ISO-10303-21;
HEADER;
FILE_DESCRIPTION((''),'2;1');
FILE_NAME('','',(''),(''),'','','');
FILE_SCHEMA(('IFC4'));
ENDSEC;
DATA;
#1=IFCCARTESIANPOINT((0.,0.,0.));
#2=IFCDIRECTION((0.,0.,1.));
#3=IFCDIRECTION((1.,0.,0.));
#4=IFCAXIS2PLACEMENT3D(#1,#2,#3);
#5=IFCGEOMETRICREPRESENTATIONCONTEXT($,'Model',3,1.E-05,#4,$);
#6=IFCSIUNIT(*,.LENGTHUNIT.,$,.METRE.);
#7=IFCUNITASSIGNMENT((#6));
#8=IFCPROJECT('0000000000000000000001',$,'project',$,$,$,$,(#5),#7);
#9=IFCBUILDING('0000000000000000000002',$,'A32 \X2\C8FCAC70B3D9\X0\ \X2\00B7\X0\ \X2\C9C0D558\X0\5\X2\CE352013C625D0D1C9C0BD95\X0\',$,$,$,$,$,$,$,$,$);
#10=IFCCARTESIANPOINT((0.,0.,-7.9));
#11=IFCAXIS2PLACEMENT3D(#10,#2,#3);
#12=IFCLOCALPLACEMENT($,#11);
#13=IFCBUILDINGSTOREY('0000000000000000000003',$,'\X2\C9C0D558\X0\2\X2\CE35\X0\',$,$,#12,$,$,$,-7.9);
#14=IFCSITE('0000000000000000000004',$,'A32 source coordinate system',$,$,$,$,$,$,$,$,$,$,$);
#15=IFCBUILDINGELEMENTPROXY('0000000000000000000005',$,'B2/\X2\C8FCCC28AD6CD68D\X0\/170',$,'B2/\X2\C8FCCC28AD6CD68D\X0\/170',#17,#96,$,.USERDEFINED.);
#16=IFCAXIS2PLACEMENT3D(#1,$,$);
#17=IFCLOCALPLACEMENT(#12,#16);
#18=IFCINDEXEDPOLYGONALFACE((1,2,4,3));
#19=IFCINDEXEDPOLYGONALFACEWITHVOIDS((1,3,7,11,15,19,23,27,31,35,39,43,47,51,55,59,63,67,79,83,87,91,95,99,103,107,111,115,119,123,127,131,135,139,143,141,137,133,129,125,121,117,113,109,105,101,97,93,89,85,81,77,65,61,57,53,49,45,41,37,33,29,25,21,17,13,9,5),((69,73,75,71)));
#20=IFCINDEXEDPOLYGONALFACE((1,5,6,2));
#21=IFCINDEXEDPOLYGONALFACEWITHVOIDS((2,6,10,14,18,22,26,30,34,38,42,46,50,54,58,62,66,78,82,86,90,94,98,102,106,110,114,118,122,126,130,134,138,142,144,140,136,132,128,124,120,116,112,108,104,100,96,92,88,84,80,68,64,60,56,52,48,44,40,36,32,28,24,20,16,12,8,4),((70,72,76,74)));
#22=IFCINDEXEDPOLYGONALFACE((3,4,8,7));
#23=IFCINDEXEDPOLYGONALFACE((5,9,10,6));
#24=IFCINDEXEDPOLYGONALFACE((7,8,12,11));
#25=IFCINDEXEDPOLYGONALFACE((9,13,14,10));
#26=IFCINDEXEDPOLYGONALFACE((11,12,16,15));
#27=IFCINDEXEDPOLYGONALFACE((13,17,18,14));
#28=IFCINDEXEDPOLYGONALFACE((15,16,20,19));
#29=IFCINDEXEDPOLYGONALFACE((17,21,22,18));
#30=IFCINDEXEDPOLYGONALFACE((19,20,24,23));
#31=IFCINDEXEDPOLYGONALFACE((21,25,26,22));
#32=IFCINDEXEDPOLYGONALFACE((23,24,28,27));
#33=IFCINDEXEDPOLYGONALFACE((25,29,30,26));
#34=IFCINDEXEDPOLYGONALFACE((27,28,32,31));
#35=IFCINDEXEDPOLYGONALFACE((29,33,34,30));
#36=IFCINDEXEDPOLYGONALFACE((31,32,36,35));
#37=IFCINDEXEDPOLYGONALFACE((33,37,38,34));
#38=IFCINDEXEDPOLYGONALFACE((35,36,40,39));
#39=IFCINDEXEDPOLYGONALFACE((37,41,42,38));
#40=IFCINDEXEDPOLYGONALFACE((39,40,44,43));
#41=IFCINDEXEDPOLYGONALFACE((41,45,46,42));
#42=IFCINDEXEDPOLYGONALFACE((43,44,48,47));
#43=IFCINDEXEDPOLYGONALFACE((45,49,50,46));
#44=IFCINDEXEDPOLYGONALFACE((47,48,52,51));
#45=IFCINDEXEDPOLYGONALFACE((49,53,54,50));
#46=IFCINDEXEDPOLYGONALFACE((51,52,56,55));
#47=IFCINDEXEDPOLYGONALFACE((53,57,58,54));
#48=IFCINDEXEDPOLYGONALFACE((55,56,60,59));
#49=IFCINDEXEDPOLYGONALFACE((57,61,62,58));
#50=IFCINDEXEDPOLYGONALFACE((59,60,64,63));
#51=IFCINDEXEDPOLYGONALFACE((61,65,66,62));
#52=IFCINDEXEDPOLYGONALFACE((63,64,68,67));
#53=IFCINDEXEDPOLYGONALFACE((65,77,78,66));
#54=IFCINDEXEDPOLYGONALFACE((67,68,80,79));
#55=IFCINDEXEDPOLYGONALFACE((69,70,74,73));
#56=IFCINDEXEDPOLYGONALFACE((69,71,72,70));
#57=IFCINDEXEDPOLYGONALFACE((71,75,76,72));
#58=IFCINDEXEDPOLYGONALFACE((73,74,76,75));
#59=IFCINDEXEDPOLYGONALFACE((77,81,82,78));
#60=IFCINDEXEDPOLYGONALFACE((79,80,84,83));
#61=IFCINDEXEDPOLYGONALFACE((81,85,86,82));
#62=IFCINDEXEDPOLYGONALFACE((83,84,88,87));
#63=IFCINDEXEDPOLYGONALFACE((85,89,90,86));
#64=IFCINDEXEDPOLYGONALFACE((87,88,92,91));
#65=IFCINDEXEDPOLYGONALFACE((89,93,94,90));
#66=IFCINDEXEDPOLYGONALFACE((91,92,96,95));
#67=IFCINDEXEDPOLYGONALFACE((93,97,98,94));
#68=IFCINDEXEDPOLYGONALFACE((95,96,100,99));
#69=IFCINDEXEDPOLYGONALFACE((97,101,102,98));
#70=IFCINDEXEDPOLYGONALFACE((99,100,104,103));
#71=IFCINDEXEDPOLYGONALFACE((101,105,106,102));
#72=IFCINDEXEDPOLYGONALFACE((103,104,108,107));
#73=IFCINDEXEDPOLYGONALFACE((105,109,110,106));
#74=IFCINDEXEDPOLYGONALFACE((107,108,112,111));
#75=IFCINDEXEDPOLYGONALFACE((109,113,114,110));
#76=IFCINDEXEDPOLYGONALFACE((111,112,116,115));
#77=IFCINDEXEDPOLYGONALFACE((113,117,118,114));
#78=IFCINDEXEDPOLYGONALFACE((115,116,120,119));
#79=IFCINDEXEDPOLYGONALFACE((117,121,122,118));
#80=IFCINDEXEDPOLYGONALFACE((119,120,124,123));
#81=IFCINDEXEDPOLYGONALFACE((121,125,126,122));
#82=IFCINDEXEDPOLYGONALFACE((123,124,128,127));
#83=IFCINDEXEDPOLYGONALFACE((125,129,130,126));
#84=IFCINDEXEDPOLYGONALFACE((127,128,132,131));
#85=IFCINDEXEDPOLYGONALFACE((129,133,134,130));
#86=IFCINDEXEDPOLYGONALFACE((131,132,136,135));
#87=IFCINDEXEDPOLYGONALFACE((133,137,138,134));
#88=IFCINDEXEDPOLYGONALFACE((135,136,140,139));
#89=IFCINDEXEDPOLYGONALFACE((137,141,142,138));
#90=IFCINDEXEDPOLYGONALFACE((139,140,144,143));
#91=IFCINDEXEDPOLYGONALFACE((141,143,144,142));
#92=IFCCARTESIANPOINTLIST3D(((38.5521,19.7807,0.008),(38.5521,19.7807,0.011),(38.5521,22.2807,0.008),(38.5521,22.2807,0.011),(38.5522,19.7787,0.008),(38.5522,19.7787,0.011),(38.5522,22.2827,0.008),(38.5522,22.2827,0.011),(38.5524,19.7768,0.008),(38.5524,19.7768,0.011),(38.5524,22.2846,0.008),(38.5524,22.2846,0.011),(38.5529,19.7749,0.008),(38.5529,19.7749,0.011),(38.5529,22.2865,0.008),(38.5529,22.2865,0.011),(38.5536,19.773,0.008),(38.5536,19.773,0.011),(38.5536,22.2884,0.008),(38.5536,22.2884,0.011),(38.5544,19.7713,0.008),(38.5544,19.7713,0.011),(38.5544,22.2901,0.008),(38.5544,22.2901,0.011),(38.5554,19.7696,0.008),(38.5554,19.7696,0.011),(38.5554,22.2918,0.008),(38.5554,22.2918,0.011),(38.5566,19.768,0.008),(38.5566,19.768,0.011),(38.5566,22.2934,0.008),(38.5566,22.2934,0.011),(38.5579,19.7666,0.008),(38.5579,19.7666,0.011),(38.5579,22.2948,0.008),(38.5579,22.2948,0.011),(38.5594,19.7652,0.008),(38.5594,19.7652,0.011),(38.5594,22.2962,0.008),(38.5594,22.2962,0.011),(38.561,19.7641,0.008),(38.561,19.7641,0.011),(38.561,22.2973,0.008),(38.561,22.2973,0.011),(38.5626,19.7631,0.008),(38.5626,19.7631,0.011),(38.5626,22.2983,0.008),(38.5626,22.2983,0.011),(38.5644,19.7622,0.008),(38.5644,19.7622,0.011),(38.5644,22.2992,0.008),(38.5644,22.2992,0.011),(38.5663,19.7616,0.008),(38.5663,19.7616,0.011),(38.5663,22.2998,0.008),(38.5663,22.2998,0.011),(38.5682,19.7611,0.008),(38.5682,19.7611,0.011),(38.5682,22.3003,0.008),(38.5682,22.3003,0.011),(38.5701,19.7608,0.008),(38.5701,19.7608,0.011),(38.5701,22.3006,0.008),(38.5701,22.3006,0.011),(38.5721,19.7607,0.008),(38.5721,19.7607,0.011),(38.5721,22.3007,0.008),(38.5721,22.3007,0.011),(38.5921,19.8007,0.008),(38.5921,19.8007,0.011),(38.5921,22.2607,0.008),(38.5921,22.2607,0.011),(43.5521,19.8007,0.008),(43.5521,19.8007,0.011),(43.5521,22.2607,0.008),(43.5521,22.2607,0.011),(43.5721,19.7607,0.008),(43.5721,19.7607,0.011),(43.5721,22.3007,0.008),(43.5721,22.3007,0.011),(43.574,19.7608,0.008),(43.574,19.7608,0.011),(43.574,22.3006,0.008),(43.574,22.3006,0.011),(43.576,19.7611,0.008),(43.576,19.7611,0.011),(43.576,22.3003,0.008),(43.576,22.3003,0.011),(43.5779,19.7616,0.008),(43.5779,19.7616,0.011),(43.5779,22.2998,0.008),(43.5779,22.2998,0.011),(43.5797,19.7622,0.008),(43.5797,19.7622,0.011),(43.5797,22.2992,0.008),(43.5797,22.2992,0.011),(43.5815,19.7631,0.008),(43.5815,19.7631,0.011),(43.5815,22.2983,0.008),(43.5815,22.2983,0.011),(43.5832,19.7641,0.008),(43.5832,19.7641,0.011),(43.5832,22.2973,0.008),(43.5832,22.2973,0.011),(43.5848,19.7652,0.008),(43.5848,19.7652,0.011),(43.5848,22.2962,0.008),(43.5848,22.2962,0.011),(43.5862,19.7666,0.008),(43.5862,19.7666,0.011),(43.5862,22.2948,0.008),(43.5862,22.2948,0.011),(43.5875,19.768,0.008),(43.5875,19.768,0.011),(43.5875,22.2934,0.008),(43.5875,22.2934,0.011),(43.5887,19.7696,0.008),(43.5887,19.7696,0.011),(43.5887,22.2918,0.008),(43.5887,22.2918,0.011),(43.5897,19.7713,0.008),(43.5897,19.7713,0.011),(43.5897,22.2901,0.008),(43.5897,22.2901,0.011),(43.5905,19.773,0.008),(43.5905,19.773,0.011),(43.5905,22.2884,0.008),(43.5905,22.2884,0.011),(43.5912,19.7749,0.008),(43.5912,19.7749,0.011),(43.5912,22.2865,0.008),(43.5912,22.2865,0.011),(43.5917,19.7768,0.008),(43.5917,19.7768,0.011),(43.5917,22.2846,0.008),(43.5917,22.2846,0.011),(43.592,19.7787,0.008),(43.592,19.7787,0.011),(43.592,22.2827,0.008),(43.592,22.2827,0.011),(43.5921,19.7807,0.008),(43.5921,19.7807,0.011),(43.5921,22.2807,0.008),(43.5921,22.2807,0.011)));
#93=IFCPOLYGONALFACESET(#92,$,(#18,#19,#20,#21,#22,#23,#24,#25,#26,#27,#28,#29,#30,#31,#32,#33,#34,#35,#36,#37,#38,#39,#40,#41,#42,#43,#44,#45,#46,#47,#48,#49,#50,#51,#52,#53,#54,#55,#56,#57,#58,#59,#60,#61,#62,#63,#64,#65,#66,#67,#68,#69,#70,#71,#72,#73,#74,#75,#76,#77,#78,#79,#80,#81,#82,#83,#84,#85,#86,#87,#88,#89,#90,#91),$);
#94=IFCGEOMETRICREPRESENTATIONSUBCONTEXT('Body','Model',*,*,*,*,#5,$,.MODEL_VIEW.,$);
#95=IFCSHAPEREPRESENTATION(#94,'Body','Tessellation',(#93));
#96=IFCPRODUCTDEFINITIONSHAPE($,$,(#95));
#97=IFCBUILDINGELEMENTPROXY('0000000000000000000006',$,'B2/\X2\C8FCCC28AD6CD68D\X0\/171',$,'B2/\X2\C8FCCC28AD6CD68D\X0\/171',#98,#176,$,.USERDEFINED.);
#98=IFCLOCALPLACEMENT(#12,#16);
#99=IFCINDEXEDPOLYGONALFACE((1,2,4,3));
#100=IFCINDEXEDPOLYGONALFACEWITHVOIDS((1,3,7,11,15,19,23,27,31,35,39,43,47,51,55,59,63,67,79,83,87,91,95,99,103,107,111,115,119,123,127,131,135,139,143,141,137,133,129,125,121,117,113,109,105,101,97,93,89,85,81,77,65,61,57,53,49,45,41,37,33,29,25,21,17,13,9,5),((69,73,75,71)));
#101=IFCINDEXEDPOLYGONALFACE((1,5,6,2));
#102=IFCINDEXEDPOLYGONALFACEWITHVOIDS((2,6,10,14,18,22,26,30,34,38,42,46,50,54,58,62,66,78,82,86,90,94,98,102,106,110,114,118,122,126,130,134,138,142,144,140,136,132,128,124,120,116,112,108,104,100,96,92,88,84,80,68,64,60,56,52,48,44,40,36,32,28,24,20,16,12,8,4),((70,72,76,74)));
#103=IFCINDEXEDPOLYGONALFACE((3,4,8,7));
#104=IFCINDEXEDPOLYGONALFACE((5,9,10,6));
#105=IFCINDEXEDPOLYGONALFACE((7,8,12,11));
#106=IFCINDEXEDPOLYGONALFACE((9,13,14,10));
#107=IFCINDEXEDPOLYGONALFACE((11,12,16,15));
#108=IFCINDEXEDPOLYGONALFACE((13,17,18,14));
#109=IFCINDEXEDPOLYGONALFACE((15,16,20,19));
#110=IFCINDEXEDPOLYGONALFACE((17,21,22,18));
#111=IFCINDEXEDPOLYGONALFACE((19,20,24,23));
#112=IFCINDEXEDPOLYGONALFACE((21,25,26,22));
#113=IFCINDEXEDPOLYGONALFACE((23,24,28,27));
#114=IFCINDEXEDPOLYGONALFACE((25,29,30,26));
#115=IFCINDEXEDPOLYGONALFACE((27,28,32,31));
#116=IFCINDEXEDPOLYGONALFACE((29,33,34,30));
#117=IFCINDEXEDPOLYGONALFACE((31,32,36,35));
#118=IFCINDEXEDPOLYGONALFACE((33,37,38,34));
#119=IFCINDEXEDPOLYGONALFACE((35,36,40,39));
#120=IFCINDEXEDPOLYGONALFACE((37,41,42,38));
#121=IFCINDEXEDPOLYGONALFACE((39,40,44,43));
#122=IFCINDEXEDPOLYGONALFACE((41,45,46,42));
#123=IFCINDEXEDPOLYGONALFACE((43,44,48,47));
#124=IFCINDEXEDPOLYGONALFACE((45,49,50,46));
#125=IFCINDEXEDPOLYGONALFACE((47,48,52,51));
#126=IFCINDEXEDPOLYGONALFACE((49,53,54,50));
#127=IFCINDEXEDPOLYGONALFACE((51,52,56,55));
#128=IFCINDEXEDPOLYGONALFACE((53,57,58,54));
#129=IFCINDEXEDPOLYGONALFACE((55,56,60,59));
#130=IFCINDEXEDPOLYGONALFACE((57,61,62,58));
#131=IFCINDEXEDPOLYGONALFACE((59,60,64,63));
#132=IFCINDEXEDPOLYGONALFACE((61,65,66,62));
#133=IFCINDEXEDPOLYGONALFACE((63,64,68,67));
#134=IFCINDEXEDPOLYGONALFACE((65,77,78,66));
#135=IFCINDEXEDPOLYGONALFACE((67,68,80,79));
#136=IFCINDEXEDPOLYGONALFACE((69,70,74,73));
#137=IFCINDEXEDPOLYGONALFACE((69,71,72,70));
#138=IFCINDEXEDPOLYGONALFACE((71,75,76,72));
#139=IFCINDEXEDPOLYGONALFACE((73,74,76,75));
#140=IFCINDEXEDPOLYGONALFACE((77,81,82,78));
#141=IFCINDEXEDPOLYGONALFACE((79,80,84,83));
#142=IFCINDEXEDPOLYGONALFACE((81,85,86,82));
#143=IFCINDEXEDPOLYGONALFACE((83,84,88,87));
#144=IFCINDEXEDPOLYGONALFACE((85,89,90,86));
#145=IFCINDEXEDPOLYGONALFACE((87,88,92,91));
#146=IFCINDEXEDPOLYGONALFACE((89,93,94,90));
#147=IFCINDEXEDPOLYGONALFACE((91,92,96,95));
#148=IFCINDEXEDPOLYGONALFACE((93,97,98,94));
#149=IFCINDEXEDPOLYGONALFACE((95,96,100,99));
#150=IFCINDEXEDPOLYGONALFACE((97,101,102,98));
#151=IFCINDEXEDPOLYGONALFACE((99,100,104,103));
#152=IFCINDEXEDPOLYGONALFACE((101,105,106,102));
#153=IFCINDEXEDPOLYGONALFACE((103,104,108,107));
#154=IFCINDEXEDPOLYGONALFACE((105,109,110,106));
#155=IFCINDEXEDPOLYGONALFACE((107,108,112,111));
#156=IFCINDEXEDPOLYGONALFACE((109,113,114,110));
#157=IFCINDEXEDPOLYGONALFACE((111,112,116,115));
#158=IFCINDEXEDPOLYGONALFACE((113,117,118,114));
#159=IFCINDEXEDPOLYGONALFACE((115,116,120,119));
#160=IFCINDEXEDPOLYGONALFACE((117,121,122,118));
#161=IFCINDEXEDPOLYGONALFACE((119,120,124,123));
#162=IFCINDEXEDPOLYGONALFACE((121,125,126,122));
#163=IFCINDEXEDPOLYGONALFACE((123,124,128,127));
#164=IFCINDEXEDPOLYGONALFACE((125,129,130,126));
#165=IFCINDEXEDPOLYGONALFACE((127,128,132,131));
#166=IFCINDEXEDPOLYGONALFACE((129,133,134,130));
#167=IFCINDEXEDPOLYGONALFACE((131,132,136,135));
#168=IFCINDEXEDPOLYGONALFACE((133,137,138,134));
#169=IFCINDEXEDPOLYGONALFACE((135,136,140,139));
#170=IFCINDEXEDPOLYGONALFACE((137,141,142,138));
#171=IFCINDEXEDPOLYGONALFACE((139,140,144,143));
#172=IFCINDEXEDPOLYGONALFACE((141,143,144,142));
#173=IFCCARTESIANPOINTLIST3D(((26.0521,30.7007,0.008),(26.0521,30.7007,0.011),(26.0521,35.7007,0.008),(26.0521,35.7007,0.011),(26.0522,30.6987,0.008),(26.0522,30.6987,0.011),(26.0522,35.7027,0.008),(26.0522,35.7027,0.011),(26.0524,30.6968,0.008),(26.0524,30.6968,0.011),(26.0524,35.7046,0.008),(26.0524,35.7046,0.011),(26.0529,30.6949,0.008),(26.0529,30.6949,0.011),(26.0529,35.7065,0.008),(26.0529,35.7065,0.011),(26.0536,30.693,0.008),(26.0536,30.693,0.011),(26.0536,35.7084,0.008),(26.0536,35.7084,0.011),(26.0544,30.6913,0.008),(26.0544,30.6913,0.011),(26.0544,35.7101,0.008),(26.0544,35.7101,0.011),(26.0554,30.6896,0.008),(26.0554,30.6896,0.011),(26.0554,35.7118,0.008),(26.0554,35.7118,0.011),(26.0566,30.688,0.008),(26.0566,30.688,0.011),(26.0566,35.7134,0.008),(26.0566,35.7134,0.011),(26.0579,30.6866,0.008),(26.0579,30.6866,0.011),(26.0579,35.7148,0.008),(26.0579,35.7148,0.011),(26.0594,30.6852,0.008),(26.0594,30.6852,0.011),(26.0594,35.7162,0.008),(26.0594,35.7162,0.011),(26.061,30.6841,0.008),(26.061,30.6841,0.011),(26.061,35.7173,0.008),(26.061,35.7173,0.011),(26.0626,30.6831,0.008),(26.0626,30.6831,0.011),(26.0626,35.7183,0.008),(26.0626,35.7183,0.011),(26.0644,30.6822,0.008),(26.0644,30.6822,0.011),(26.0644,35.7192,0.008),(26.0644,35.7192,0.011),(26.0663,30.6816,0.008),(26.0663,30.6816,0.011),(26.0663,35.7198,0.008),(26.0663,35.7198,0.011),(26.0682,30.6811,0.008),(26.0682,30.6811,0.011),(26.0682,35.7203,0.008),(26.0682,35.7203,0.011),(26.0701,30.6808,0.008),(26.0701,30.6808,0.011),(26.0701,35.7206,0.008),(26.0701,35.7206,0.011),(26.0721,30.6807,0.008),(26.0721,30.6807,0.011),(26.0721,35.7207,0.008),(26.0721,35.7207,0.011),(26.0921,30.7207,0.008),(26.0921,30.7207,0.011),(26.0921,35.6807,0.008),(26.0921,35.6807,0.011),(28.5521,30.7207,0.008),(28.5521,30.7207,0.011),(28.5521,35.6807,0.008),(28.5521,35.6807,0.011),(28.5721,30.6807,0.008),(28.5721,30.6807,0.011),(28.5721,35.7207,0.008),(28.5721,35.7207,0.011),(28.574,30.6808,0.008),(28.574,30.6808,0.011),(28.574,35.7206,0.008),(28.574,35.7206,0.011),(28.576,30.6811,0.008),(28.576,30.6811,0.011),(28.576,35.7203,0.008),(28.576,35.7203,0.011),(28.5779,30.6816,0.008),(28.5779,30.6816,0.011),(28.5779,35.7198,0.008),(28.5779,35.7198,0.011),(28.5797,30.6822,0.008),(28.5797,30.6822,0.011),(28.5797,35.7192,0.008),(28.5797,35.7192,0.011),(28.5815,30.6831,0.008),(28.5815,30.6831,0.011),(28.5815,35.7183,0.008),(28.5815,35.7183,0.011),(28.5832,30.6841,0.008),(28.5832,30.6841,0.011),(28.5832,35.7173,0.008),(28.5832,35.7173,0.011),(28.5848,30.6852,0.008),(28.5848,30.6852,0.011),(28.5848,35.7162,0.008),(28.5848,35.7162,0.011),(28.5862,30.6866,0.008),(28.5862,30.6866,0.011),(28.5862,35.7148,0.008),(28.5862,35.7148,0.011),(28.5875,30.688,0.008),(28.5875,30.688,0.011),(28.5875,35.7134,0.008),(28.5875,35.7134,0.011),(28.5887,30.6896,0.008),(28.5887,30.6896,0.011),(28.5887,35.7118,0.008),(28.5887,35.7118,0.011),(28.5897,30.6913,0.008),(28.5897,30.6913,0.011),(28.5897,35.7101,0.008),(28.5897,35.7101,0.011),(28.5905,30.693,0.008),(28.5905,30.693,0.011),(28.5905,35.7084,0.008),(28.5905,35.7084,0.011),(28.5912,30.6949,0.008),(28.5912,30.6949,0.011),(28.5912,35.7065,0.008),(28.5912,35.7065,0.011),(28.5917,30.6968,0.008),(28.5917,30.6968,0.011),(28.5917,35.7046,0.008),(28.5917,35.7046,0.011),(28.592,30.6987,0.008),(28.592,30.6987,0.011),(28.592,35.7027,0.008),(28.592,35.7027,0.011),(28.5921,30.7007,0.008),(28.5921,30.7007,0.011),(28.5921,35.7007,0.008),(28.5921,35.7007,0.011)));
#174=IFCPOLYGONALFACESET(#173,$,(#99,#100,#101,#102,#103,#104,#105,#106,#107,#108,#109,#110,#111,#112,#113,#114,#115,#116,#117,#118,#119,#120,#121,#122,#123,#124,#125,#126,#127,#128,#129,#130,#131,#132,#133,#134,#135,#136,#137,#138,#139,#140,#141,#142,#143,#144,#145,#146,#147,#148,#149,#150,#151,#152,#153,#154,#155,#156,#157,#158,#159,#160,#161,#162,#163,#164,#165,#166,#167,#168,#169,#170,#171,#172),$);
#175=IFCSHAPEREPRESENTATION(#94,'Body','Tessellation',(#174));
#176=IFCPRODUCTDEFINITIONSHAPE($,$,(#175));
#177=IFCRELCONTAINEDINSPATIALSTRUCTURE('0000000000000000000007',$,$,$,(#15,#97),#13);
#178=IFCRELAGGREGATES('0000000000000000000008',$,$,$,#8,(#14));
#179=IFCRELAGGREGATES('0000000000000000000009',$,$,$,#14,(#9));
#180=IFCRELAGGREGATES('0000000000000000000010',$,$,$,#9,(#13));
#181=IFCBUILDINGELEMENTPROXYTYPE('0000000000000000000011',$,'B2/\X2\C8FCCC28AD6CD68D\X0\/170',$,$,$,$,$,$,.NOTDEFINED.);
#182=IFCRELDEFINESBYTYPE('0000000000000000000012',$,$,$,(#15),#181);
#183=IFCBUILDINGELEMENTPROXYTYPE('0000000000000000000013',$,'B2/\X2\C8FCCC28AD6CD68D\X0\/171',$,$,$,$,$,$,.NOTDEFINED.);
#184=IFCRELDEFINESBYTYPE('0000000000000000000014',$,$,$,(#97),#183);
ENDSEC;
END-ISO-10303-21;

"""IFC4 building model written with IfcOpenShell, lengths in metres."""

from ifc_helpers import new_model, si_unit, frame, origin, origin_with_axes, place, context, subcontext, project, spatial, polyline, outline, extrude, source, transform, mapped, type_object, type_shapes, element, save


model = new_model("IFC4")

# Units and contexts
model_context = context("Model", 3, precision=1e-05, world=origin_with_axes())
body_context = subcontext(model_context, "Body", "Model", "MODEL_VIEW")
ifc_project = project(units=[si_unit("LENGTHUNIT", "METRE")], contexts=[model_context])

# Site, building, storey
site = spatial("IfcSite", under=ifc_project, Name="A32 source coordinate system")
building = spatial("IfcBuilding", under=site, Name="A32 주거동 · 지하5층–옥탑지붕")
storey_placement = place(None, frame((0.0, 0.0, -7.9), z_axis=(0.0, 0.0, 1.0), x_axis=(1.0, 0.0, 0.0)))
storey = spatial("IfcBuildingStorey", under=building, at=storey_placement, Name="지하2층", Elevation=-7.9)

# Building element proxies
building_element_proxy_type_1 = type_object("IfcBuildingElementProxyType", Name="B2/주차구획/170", PredefinedType="NOTDEFINED")
shared_shape_1 = source(origin(), body_context, "Body", "SweptSolid", [
    extrude(outline(polyline([(43.5721, 22.3007), (43.574, 22.3006), (43.576, 22.3003), (43.5779, 22.2998), (43.5797, 22.2992), (43.5815, 22.2983), (43.5832, 22.2973), (43.5848, 22.2962), (43.5862, 22.2948), (43.5875, 22.2934), (43.5887, 22.2918), (43.5897, 22.2901), (43.5905, 22.2884), (43.5912, 22.2865), (43.5917, 22.2846), (43.592, 22.2827), (43.5921, 22.2807), (43.5921, 19.7807), (43.592, 19.7787), (43.5917, 19.7768), (43.5912, 19.7749), (43.5905, 19.773), (43.5897, 19.7713), (43.5887, 19.7696), (43.5875, 19.768), (43.5862, 19.7666), (43.5848, 19.7652), (43.5832, 19.7641), (43.5815, 19.7631), (43.5797, 19.7622), (43.5779, 19.7616), (43.576, 19.7611), (43.574, 19.7608), (43.5721, 19.7607), (38.5721, 19.7607), (38.5701, 19.7608), (38.5682, 19.7611), (38.5663, 19.7616), (38.5644, 19.7622), (38.5626, 19.7631), (38.561, 19.7641), (38.5594, 19.7652), (38.5579, 19.7666), (38.5566, 19.768), (38.5554, 19.7696), (38.5544, 19.7713), (38.5536, 19.773), (38.5529, 19.7749), (38.5524, 19.7768), (38.5522, 19.7787), (38.5521, 19.7807), (38.5521, 22.2807), (38.5522, 22.2827), (38.5524, 22.2846), (38.5529, 22.2865), (38.5536, 22.2884), (38.5544, 22.2901), (38.5554, 22.2918), (38.5566, 22.2934), (38.5579, 22.2948), (38.5594, 22.2962), (38.561, 22.2973), (38.5626, 22.2983), (38.5644, 22.2992), (38.5663, 22.2998), (38.5682, 22.3003), (38.5701, 22.3006), (38.5721, 22.3007), (43.5721, 22.3007)]), holes=[polyline([(43.5521, 22.2607), (38.5921, 22.2607), (38.5921, 19.8007), (43.5521, 19.8007), (43.5521, 22.2607)])]), frame((0.0, 0.0, 0.008)), (0.0, 0.0, 1.0), 0.003),
])
type_shapes(building_element_proxy_type_1, [shared_shape_1])
proxy_1_placement = place(storey_placement, origin_with_axes())
element("IfcBuildingElementProxy", 1, at=proxy_1_placement, inside=storey, type_object=building_element_proxy_type_1, Name="B2/주차구획/170", ObjectType="B2/주차구획/170", PredefinedType="USERDEFINED", context=body_context, shape_type="MappedRepresentation", body=[
    mapped(shared_shape_1, transform((0.0, 0.0, 0.0), scale=1.0)),
])
building_element_proxy_type_2 = type_object("IfcBuildingElementProxyType", Name="B2/주차구획/171", PredefinedType="NOTDEFINED")
shared_shape_2 = source(origin(), body_context, "Body", "SweptSolid", [
    extrude(outline(polyline([(26.0521, 35.7007), (26.0522, 35.7027), (26.0524, 35.7046), (26.0529, 35.7065), (26.0536, 35.7084), (26.0544, 35.7101), (26.0554, 35.7118), (26.0566, 35.7134), (26.0579, 35.7148), (26.0594, 35.7162), (26.061, 35.7173), (26.0626, 35.7183), (26.0644, 35.7192), (26.0663, 35.7198), (26.0682, 35.7203), (26.0701, 35.7206), (26.0721, 35.7207), (28.5721, 35.7207), (28.574, 35.7206), (28.576, 35.7203), (28.5779, 35.7198), (28.5797, 35.7192), (28.5815, 35.7183), (28.5832, 35.7173), (28.5848, 35.7162), (28.5862, 35.7148), (28.5875, 35.7134), (28.5887, 35.7118), (28.5897, 35.7101), (28.5905, 35.7084), (28.5912, 35.7065), (28.5917, 35.7046), (28.592, 35.7027), (28.5921, 35.7007), (28.5921, 30.7007), (28.592, 30.6987), (28.5917, 30.6968), (28.5912, 30.6949), (28.5905, 30.693), (28.5897, 30.6913), (28.5887, 30.6896), (28.5875, 30.688), (28.5862, 30.6866), (28.5848, 30.6852), (28.5832, 30.6841), (28.5815, 30.6831), (28.5797, 30.6822), (28.5779, 30.6816), (28.576, 30.6811), (28.574, 30.6808), (28.5721, 30.6807), (26.0721, 30.6807), (26.0701, 30.6808), (26.0682, 30.6811), (26.0663, 30.6816), (26.0644, 30.6822), (26.0626, 30.6831), (26.061, 30.6841), (26.0594, 30.6852), (26.0579, 30.6866), (26.0566, 30.688), (26.0554, 30.6896), (26.0544, 30.6913), (26.0536, 30.693), (26.0529, 30.6949), (26.0524, 30.6968), (26.0522, 30.6987), (26.0521, 30.7007), (26.0521, 35.7007)]), holes=[polyline([(26.0921, 35.6807), (26.0921, 30.7207), (28.5521, 30.7207), (28.5521, 35.6807), (26.0921, 35.6807)])]), frame((0.0, 0.0, 0.008)), (0.0, 0.0, 1.0), 0.003),
])
type_shapes(building_element_proxy_type_2, [shared_shape_2])
proxy_2_placement = place(storey_placement, origin_with_axes())
element("IfcBuildingElementProxy", 2, at=proxy_2_placement, inside=storey, type_object=building_element_proxy_type_2, Name="B2/주차구획/171", ObjectType="B2/주차구획/171", PredefinedType="USERDEFINED", context=body_context, shape_type="MappedRepresentation", body=[
    mapped(shared_shape_2, transform((0.0, 0.0, 0.0), scale=1.0)),
])

save(model, "model.ifc")
